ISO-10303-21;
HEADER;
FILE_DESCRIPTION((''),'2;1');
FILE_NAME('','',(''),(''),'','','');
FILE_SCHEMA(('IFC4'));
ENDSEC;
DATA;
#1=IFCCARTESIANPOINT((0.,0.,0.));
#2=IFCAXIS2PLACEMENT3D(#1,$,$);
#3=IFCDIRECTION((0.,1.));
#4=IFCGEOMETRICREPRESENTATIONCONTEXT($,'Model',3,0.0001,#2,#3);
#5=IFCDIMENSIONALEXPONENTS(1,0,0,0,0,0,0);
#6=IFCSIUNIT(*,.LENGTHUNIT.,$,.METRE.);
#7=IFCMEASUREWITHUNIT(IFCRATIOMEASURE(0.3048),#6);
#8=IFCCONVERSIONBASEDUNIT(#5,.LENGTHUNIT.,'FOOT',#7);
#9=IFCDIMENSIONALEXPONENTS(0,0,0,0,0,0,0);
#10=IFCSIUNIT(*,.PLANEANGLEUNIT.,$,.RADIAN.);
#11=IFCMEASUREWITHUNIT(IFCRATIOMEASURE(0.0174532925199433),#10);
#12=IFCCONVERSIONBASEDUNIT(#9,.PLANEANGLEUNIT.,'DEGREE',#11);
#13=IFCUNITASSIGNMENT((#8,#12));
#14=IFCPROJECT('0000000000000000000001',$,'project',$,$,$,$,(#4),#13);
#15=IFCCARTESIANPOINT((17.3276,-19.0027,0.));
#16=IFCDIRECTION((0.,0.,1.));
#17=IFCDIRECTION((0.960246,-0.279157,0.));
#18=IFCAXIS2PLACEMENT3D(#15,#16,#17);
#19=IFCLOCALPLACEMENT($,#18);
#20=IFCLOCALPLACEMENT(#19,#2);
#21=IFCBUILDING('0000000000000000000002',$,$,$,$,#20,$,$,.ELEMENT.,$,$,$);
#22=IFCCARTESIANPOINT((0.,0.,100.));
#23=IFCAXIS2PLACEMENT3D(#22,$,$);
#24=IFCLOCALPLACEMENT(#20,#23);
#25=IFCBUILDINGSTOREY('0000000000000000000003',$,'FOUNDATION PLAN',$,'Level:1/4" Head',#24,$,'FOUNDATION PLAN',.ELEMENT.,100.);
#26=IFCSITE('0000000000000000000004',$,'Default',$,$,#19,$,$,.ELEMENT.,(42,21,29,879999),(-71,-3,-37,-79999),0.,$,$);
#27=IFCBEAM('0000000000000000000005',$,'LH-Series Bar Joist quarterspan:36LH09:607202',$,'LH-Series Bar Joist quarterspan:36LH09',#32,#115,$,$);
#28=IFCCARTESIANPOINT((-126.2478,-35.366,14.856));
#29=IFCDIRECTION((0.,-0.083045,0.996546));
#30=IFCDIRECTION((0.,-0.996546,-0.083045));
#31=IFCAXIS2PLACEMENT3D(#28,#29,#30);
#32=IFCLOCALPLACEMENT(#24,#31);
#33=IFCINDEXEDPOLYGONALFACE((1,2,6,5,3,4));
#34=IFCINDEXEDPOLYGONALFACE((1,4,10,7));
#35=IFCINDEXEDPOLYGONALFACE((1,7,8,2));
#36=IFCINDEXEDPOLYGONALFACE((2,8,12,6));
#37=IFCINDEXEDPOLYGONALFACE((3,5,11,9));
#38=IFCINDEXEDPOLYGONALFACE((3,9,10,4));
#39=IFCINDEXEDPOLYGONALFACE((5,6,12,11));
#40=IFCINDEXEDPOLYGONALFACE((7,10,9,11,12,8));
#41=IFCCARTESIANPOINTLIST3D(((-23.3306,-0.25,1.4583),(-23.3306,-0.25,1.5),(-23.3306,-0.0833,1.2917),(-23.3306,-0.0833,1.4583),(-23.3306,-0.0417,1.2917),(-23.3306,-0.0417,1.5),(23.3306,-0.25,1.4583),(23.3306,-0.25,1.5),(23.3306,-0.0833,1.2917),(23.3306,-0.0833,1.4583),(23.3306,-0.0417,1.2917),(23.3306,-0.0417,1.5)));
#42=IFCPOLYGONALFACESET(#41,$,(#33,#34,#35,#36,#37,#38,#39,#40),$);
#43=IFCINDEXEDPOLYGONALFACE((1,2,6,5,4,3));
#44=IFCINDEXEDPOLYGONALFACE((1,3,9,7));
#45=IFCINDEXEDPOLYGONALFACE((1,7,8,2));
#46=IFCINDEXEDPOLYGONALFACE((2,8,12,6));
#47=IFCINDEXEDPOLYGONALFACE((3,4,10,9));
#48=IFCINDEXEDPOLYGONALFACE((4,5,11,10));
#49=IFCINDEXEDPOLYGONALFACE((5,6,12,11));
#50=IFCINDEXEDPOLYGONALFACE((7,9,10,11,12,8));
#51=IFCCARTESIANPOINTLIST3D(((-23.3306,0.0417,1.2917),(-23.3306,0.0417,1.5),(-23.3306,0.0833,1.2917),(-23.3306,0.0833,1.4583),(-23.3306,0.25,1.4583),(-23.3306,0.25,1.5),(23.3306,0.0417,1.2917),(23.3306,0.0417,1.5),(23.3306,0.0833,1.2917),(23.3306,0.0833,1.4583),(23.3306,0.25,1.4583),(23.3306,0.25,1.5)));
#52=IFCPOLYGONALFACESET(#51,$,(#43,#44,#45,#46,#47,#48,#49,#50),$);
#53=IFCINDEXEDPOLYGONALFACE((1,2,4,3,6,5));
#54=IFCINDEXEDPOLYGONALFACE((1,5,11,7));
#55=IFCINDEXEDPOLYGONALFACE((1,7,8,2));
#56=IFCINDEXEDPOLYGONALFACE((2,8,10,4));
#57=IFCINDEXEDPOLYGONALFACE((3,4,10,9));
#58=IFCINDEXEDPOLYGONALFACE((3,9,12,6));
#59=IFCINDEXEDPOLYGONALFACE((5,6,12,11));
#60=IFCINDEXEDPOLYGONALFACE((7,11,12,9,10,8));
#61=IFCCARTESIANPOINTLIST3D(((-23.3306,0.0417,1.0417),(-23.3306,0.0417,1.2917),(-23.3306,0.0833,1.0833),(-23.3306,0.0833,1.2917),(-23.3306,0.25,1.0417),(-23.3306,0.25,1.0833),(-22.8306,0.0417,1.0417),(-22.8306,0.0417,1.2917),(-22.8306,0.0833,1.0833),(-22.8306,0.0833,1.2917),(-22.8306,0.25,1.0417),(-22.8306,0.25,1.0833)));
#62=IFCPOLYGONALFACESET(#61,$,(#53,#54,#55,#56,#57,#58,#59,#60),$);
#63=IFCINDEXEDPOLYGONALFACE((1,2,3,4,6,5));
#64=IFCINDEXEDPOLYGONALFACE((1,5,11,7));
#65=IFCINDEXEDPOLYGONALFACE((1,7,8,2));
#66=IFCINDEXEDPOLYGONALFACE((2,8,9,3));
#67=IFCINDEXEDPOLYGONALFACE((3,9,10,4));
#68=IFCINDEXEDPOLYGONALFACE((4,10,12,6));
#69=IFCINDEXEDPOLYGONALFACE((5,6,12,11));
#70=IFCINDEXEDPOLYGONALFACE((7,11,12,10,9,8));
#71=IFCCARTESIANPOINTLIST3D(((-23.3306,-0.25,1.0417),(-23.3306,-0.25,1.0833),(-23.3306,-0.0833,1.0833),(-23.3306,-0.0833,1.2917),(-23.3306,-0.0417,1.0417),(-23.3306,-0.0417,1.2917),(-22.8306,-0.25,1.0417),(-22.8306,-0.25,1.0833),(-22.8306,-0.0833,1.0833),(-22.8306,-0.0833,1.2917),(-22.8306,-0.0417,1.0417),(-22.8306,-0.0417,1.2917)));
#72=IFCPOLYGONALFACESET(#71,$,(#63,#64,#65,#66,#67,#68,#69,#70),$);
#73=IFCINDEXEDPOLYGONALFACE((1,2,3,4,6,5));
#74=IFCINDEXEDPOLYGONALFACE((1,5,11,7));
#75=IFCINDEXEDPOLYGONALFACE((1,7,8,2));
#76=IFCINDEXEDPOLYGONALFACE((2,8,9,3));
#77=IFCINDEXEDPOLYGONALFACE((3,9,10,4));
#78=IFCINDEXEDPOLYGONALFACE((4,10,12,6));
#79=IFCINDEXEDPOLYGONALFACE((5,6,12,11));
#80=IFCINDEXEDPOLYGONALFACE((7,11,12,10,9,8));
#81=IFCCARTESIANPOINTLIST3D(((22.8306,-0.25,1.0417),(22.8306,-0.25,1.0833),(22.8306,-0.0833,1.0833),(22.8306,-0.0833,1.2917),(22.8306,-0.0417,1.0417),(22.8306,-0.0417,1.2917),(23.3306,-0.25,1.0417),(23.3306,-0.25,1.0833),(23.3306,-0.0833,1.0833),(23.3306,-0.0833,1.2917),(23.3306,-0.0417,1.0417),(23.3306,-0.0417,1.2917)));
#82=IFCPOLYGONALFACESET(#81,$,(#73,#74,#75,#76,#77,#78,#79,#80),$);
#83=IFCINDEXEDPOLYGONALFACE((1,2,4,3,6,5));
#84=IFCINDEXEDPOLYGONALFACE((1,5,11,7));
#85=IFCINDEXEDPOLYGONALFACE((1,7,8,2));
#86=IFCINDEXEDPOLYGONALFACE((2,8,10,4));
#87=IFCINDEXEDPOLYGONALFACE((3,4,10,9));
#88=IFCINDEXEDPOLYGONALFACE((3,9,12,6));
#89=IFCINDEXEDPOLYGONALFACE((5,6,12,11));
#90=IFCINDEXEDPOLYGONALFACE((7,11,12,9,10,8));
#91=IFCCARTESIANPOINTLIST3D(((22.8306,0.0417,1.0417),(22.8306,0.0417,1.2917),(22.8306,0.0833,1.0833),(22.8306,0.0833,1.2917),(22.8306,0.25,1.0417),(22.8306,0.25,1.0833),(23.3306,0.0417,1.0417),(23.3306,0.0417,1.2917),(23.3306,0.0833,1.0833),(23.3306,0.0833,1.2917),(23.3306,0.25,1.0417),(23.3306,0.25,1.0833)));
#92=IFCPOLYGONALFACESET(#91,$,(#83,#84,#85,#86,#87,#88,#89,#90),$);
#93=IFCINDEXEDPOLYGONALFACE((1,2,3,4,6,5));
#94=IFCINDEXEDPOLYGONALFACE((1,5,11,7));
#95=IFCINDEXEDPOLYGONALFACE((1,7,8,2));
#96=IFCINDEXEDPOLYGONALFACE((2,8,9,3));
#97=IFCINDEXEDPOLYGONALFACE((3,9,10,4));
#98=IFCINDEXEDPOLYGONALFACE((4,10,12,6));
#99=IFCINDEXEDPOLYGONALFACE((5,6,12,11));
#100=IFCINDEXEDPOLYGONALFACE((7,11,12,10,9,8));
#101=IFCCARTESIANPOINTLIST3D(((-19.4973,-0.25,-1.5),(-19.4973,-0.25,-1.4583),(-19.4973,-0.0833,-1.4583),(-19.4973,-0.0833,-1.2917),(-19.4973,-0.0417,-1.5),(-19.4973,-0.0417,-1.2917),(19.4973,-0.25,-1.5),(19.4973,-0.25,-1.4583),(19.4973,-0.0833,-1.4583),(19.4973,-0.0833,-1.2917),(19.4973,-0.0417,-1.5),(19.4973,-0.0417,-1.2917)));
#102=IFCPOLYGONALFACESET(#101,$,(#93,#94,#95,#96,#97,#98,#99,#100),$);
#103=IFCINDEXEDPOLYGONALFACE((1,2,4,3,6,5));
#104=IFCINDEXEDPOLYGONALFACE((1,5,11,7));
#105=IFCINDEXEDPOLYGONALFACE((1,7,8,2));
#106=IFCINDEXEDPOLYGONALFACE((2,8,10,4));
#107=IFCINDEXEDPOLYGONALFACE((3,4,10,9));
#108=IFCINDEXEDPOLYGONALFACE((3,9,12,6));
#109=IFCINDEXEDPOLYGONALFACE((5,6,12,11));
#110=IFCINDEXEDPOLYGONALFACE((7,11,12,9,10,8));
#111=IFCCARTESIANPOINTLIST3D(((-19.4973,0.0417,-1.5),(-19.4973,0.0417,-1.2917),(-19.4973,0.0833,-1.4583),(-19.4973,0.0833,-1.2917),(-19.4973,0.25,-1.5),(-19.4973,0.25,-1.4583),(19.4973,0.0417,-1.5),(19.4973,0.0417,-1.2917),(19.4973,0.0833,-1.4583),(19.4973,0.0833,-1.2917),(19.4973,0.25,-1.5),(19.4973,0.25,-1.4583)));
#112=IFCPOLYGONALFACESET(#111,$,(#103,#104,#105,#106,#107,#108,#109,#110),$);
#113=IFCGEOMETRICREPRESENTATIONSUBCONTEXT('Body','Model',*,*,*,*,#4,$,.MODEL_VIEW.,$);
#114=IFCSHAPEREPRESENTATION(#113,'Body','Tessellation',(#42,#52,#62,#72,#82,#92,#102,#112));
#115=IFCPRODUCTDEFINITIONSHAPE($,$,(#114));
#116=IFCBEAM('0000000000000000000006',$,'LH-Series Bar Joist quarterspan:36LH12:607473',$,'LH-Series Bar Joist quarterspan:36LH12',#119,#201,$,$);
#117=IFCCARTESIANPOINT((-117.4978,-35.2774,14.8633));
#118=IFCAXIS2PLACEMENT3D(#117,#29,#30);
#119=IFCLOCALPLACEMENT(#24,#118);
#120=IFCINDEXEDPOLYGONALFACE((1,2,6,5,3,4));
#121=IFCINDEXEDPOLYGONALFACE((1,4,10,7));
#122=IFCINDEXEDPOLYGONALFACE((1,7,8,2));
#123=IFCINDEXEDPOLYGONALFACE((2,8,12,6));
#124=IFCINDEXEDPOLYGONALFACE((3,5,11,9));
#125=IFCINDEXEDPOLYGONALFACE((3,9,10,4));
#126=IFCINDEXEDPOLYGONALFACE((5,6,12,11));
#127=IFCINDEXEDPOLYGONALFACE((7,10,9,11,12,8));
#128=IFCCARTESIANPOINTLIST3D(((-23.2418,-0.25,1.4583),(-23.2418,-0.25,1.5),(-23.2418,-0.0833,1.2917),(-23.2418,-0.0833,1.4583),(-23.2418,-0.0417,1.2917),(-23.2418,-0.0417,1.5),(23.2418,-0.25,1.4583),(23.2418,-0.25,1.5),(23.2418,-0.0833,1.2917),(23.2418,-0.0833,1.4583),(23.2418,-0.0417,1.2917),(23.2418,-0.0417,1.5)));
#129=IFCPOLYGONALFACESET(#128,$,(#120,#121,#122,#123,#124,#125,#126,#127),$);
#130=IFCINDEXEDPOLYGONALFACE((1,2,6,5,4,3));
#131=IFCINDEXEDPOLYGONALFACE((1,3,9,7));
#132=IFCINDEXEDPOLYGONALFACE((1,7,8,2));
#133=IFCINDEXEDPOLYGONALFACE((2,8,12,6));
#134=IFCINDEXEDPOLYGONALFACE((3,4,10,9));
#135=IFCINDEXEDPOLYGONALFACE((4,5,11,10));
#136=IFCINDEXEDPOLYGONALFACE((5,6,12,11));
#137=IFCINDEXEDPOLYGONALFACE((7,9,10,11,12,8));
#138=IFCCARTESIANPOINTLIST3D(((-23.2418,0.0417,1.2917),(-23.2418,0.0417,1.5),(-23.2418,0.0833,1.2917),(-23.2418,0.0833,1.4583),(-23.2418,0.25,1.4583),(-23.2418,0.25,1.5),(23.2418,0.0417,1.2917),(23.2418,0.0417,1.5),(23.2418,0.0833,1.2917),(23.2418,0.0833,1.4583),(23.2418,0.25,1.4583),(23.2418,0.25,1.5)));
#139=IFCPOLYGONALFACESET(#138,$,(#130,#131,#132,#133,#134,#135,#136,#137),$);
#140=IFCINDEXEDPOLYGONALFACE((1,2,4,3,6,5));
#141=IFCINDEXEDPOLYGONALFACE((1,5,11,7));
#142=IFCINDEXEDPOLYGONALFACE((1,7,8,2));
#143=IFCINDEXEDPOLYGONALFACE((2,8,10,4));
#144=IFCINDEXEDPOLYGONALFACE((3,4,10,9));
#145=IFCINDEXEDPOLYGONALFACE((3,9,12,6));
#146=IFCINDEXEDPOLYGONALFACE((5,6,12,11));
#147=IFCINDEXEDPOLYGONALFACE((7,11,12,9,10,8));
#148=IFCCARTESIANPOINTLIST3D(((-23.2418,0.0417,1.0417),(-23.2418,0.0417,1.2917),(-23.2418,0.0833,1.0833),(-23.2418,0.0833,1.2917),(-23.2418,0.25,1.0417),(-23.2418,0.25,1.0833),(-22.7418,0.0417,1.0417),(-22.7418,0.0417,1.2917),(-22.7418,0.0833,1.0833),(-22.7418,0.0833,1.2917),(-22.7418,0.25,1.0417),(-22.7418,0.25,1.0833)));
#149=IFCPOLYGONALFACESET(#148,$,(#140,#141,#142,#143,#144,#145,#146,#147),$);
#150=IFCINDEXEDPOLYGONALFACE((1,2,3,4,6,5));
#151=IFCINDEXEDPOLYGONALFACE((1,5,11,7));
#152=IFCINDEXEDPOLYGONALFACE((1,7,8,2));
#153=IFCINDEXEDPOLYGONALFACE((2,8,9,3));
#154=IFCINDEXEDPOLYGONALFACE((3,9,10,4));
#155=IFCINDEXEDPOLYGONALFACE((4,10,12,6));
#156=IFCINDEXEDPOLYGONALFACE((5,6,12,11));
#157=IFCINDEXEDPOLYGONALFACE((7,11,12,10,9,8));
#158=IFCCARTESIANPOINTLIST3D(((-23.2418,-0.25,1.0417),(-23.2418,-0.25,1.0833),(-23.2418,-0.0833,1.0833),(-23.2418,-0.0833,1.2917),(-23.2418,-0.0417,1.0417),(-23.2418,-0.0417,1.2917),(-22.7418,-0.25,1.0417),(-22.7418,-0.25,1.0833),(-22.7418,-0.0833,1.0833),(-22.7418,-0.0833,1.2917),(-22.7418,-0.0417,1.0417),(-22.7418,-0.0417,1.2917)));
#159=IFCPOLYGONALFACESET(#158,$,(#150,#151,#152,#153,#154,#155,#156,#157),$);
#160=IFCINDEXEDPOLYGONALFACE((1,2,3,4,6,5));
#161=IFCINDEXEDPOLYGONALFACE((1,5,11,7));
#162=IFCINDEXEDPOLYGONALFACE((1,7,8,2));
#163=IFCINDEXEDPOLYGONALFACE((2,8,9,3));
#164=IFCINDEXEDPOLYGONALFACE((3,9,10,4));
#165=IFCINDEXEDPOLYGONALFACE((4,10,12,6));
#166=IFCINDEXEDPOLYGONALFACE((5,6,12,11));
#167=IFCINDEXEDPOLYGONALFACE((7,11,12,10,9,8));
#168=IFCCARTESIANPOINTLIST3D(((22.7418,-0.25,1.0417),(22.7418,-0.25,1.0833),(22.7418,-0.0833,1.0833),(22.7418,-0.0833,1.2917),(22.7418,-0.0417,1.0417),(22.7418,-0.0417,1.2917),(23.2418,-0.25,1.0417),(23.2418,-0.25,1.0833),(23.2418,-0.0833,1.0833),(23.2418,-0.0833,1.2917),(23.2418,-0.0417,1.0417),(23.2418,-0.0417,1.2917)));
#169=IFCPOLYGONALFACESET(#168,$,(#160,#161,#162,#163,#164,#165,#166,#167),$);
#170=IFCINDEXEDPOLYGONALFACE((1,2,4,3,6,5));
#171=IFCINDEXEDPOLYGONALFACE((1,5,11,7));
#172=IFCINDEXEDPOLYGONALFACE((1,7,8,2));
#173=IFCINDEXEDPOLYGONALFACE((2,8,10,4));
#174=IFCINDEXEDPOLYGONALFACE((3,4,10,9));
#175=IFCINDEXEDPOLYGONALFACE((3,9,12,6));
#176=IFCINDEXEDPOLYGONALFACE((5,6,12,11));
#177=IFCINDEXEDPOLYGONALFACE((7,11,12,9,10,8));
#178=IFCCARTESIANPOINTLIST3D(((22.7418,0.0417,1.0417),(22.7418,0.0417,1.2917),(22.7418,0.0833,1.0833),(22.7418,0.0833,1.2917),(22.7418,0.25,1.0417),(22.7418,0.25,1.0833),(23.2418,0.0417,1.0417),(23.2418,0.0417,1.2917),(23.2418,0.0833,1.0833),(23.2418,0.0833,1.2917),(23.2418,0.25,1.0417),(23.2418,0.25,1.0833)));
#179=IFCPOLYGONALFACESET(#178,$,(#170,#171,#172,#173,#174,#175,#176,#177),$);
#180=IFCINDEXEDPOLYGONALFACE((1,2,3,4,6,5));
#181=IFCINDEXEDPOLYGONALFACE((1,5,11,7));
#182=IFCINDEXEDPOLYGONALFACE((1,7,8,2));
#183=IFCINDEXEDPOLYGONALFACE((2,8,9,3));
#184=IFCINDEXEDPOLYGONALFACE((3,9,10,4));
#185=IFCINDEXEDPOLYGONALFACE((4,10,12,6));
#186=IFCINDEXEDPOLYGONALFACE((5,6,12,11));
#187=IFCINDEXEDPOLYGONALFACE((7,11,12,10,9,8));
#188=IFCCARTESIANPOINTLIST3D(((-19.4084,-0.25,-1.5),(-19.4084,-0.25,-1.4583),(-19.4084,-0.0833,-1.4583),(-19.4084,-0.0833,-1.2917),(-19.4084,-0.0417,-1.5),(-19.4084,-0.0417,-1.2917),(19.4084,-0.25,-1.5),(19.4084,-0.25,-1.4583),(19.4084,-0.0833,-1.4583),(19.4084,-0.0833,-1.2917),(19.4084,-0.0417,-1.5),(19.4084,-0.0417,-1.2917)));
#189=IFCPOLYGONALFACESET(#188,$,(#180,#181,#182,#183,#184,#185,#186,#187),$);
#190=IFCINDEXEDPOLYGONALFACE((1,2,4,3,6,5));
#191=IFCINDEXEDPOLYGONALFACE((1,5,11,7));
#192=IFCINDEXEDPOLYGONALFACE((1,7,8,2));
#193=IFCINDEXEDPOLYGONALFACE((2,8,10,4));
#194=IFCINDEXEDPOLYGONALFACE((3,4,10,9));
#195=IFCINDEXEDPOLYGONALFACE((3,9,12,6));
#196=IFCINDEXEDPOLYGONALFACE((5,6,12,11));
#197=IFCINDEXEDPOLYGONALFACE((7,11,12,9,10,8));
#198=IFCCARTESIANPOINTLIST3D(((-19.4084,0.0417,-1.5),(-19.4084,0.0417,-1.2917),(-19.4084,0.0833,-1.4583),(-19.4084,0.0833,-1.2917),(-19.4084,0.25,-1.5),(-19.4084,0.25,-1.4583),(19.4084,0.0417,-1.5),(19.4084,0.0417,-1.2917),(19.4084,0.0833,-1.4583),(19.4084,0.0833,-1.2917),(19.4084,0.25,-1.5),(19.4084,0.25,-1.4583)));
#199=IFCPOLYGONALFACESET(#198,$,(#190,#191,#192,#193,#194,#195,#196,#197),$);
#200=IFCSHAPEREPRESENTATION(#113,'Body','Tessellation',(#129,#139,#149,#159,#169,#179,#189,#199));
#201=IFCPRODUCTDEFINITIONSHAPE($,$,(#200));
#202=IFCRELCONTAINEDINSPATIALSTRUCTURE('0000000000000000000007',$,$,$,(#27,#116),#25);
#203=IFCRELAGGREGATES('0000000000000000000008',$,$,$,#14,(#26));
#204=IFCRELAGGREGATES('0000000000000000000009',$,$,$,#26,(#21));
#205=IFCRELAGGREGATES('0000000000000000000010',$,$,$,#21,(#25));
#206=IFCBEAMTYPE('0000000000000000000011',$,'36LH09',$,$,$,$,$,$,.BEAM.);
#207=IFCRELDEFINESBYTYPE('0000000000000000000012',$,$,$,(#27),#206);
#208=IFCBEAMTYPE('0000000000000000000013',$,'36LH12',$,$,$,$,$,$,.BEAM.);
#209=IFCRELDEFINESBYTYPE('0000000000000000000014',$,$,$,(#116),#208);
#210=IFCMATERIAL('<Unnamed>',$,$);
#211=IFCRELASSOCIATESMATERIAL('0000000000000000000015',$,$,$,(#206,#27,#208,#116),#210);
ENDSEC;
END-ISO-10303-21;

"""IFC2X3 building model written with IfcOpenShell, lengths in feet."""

from ifc_helpers import new_model, entity, si_unit, converted_unit, direction, frame, origin, place, context, subcontext, project, spatial, polyline, outline, extrude, source, transform, mapped, material, type_object, type_shapes, element, save


model = new_model("IFC2X3")

# Units and contexts
model_context = context("Model", 3, precision=0.0001, world=origin(), true_north=direction((0.0, 1.0)))
body_context = subcontext(model_context, "Body", "Model", "MODEL_VIEW")
ifc_project = project(units=[converted_unit("LENGTHUNIT", "FOOT", entity("IfcRatioMeasure", 0.3048), si_unit("LENGTHUNIT", "METRE"), dimensions=[1, 0, 0, 0, 0, 0, 0]), converted_unit("PLANEANGLEUNIT", "DEGREE", entity("IfcRatioMeasure", 0.0174532925199433), si_unit("PLANEANGLEUNIT", "RADIAN"), dimensions=[0, 0, 0, 0, 0, 0, 0])], contexts=[model_context])

# Site, building, storey
site_placement = place(None, frame((17.3276, -19.0027, 0.0), z_axis=(0.0, 0.0, 1.0), x_axis=(0.960246, -0.279157, 0.0)))
site = spatial("IfcSite", under=ifc_project, at=site_placement, Name="Default", CompositionType="ELEMENT", RefLatitude=(42, 21, 29, 879999), RefLongitude=(-71, -3, -37, -79999), RefElevation=0.0)
building_placement = place(site_placement, origin())
building = spatial("IfcBuilding", under=site, at=building_placement, CompositionType="ELEMENT")
storey_placement = place(building_placement, frame((0.0, 0.0, 100.0)))
storey = spatial("IfcBuildingStorey", under=building, at=storey_placement, Name="FOUNDATION PLAN", ObjectType="Level:1/4\" Head", LongName="FOUNDATION PLAN", CompositionType="ELEMENT", Elevation=100.0)

# Shared definitions
ifc_material_1 = material(Name="<Unnamed>")

# Beams
beam_type_1 = type_object("IfcBeamType", Name="36LH09", PredefinedType="BEAM", material=ifc_material_1)
shared_shape_1 = source(origin(), body_context, "Body", "SweptSolid", [
    extrude(outline(polyline([(-0.0833, -0.125), (-0.0417, -0.125), (-0.0417, 0.0417), (0.125, 0.0417), (0.125, 0.0833), (-0.0833, 0.0833), (-0.0833, -0.125)])), frame((-23.3306, -0.125, 1.4167), z_axis=(1.0, 0.0, 0.0), x_axis=(0.0, 0.0, -1.0)), (0.0, 0.0, 1.0), 46.6612),
    extrude(outline(polyline([(-0.0833, -0.0833), (0.125, -0.0833), (0.125, -0.0417), (-0.0417, -0.0417), (-0.0417, 0.125), (-0.0833, 0.125), (-0.0833, -0.0833)])), frame((-23.3306, 0.125, 1.4167), z_axis=(1.0, 0.0, 0.0), x_axis=(0.0, 0.0, -1.0)), (0.0, 0.0, 1.0), 46.6612),
    extrude(outline(polyline([(-0.1528, -0.0833), (0.0972, -0.0833), (0.0972, 0.125), (0.0556, 0.125), (0.0556, -0.0417), (-0.1528, -0.0417), (-0.1528, -0.0833)])), frame((-23.3306, 0.125, 1.1389), z_axis=(1.0, 0.0, 0.0), x_axis=(0.0, 0.0, -1.0)), (0.0, 0.0, 1.0), 0.5),
    extrude(outline(polyline([(0.0556, -0.125), (0.0972, -0.125), (0.0972, 0.0833), (-0.1528, 0.0833), (-0.1528, 0.0417), (0.0556, 0.0417), (0.0556, -0.125)])), frame((-23.3306, -0.125, 1.1389), z_axis=(1.0, 0.0, 0.0), x_axis=(0.0, 0.0, -1.0)), (0.0, 0.0, 1.0), 0.5),
    extrude(outline(polyline([(0.0556, -0.125), (0.0972, -0.125), (0.0972, 0.0833), (-0.1528, 0.0833), (-0.1528, 0.0417), (0.0556, 0.0417), (0.0556, -0.125)])), frame((22.8306, -0.125, 1.1389), z_axis=(1.0, 0.0, 0.0), x_axis=(0.0, 0.0, -1.0)), (0.0, 0.0, 1.0), 0.5),
    extrude(outline(polyline([(-0.1528, -0.0833), (0.0972, -0.0833), (0.0972, 0.125), (0.0556, 0.125), (0.0556, -0.0417), (-0.1528, -0.0417), (-0.1528, -0.0833)])), frame((22.8306, 0.125, 1.1389), z_axis=(1.0, 0.0, 0.0), x_axis=(0.0, 0.0, -1.0)), (0.0, 0.0, 1.0), 0.5),
    extrude(outline(polyline([(0.0417, -0.125), (0.0833, -0.125), (0.0833, 0.0833), (-0.125, 0.0833), (-0.125, 0.0417), (0.0417, 0.0417), (0.0417, -0.125)])), frame((-19.4973, -0.125, -1.4167), z_axis=(1.0, 0.0, 0.0), x_axis=(0.0, 0.0, -1.0)), (0.0, 0.0, 1.0), 38.9945),
    extrude(outline(polyline([(-0.125, -0.0833), (0.0833, -0.0833), (0.0833, 0.125), (0.0417, 0.125), (0.0417, -0.0417), (-0.125, -0.0417), (-0.125, -0.0833)])), frame((-19.4973, 0.125, -1.4167), z_axis=(1.0, 0.0, 0.0), x_axis=(0.0, 0.0, -1.0)), (0.0, 0.0, 1.0), 38.9945),
])
type_shapes(beam_type_1, [shared_shape_1])
beam_1_placement = place(storey_placement, frame((-126.2478, -35.366, 14.856), z_axis=(0.0, -0.083045, 0.996546), x_axis=(0.0, -0.996546, -0.083045)))
element("IfcBeam", 1, at=beam_1_placement, inside=storey, type_object=beam_type_1, material=ifc_material_1, Name="LH-Series Bar Joist quarterspan:36LH09:607202", ObjectType="LH-Series Bar Joist quarterspan:36LH09", context=body_context, shape_type="MappedRepresentation", body=[
    mapped(shared_shape_1, transform((0.0, 0.0, 0.0), scale=1.0)),
])
beam_type_2 = type_object("IfcBeamType", Name="36LH12", PredefinedType="BEAM", material=ifc_material_1)
shared_shape_2 = source(origin(), body_context, "Body", "SweptSolid", [
    extrude(outline(polyline([(-0.0833, -0.125), (-0.0417, -0.125), (-0.0417, 0.0417), (0.125, 0.0417), (0.125, 0.0833), (-0.0833, 0.0833), (-0.0833, -0.125)])), frame((-23.2418, -0.125, 1.4167), z_axis=(1.0, 0.0, 0.0), x_axis=(0.0, 0.0, -1.0)), (0.0, 0.0, 1.0), 46.4835),
    extrude(outline(polyline([(-0.0833, -0.0833), (0.125, -0.0833), (0.125, -0.0417), (-0.0417, -0.0417), (-0.0417, 0.125), (-0.0833, 0.125), (-0.0833, -0.0833)])), frame((-23.2418, 0.125, 1.4167), z_axis=(1.0, 0.0, 0.0), x_axis=(0.0, 0.0, -1.0)), (0.0, 0.0, 1.0), 46.4835),
    extrude(outline(polyline([(-0.1528, -0.0833), (0.0972, -0.0833), (0.0972, 0.125), (0.0556, 0.125), (0.0556, -0.0417), (-0.1528, -0.0417), (-0.1528, -0.0833)])), frame((-23.2418, 0.125, 1.1389), z_axis=(1.0, 0.0, 0.0), x_axis=(0.0, 0.0, -1.0)), (0.0, 0.0, 1.0), 0.5),
    extrude(outline(polyline([(0.0556, -0.125), (0.0972, -0.125), (0.0972, 0.0833), (-0.1528, 0.0833), (-0.1528, 0.0417), (0.0556, 0.0417), (0.0556, -0.125)])), frame((-23.2418, -0.125, 1.1389), z_axis=(1.0, 0.0, 0.0), x_axis=(0.0, 0.0, -1.0)), (0.0, 0.0, 1.0), 0.5),
    extrude(outline(polyline([(0.0556, -0.125), (0.0972, -0.125), (0.0972, 0.0833), (-0.1528, 0.0833), (-0.1528, 0.0417), (0.0556, 0.0417), (0.0556, -0.125)])), frame((22.7418, -0.125, 1.1389), z_axis=(1.0, 0.0, 0.0), x_axis=(0.0, 0.0, -1.0)), (0.0, 0.0, 1.0), 0.5),
    extrude(outline(polyline([(-0.1528, -0.0833), (0.0972, -0.0833), (0.0972, 0.125), (0.0556, 0.125), (0.0556, -0.0417), (-0.1528, -0.0417), (-0.1528, -0.0833)])), frame((22.7418, 0.125, 1.1389), z_axis=(1.0, 0.0, 0.0), x_axis=(0.0, 0.0, -1.0)), (0.0, 0.0, 1.0), 0.5),
    extrude(outline(polyline([(0.0417, -0.125), (0.0833, -0.125), (0.0833, 0.0833), (-0.125, 0.0833), (-0.125, 0.0417), (0.0417, 0.0417), (0.0417, -0.125)])), frame((-19.4084, -0.125, -1.4167), z_axis=(1.0, 0.0, 0.0), x_axis=(0.0, 0.0, -1.0)), (0.0, 0.0, 1.0), 38.8169),
    extrude(outline(polyline([(-0.125, -0.0833), (0.0833, -0.0833), (0.0833, 0.125), (0.0417, 0.125), (0.0417, -0.0417), (-0.125, -0.0417), (-0.125, -0.0833)])), frame((-19.4084, 0.125, -1.4167), z_axis=(1.0, 0.0, 0.0), x_axis=(0.0, 0.0, -1.0)), (0.0, 0.0, 1.0), 38.8169),
])
type_shapes(beam_type_2, [shared_shape_2])
for number, where, z_axis, x_axis, name in (
    (2, (-117.4978, -35.2774, 14.8633), (0.0, -0.083045, 0.996546), (0.0, -0.996546, -0.083045), "LH-Series Bar Joist quarterspan:36LH12:607473"),
):
    element("IfcBeam", number, at=place(storey_placement, frame(where, z_axis=z_axis, x_axis=x_axis)), inside=storey, type_object=beam_type_2, material=ifc_material_1, Name=name, ObjectType="LH-Series Bar Joist quarterspan:36LH12", context=body_context, shape_type="MappedRepresentation", body=[
        mapped(shared_shape_2, transform((0.0, 0.0, 0.0), scale=1.0)),
    ])

save(model, "model.ifc")
